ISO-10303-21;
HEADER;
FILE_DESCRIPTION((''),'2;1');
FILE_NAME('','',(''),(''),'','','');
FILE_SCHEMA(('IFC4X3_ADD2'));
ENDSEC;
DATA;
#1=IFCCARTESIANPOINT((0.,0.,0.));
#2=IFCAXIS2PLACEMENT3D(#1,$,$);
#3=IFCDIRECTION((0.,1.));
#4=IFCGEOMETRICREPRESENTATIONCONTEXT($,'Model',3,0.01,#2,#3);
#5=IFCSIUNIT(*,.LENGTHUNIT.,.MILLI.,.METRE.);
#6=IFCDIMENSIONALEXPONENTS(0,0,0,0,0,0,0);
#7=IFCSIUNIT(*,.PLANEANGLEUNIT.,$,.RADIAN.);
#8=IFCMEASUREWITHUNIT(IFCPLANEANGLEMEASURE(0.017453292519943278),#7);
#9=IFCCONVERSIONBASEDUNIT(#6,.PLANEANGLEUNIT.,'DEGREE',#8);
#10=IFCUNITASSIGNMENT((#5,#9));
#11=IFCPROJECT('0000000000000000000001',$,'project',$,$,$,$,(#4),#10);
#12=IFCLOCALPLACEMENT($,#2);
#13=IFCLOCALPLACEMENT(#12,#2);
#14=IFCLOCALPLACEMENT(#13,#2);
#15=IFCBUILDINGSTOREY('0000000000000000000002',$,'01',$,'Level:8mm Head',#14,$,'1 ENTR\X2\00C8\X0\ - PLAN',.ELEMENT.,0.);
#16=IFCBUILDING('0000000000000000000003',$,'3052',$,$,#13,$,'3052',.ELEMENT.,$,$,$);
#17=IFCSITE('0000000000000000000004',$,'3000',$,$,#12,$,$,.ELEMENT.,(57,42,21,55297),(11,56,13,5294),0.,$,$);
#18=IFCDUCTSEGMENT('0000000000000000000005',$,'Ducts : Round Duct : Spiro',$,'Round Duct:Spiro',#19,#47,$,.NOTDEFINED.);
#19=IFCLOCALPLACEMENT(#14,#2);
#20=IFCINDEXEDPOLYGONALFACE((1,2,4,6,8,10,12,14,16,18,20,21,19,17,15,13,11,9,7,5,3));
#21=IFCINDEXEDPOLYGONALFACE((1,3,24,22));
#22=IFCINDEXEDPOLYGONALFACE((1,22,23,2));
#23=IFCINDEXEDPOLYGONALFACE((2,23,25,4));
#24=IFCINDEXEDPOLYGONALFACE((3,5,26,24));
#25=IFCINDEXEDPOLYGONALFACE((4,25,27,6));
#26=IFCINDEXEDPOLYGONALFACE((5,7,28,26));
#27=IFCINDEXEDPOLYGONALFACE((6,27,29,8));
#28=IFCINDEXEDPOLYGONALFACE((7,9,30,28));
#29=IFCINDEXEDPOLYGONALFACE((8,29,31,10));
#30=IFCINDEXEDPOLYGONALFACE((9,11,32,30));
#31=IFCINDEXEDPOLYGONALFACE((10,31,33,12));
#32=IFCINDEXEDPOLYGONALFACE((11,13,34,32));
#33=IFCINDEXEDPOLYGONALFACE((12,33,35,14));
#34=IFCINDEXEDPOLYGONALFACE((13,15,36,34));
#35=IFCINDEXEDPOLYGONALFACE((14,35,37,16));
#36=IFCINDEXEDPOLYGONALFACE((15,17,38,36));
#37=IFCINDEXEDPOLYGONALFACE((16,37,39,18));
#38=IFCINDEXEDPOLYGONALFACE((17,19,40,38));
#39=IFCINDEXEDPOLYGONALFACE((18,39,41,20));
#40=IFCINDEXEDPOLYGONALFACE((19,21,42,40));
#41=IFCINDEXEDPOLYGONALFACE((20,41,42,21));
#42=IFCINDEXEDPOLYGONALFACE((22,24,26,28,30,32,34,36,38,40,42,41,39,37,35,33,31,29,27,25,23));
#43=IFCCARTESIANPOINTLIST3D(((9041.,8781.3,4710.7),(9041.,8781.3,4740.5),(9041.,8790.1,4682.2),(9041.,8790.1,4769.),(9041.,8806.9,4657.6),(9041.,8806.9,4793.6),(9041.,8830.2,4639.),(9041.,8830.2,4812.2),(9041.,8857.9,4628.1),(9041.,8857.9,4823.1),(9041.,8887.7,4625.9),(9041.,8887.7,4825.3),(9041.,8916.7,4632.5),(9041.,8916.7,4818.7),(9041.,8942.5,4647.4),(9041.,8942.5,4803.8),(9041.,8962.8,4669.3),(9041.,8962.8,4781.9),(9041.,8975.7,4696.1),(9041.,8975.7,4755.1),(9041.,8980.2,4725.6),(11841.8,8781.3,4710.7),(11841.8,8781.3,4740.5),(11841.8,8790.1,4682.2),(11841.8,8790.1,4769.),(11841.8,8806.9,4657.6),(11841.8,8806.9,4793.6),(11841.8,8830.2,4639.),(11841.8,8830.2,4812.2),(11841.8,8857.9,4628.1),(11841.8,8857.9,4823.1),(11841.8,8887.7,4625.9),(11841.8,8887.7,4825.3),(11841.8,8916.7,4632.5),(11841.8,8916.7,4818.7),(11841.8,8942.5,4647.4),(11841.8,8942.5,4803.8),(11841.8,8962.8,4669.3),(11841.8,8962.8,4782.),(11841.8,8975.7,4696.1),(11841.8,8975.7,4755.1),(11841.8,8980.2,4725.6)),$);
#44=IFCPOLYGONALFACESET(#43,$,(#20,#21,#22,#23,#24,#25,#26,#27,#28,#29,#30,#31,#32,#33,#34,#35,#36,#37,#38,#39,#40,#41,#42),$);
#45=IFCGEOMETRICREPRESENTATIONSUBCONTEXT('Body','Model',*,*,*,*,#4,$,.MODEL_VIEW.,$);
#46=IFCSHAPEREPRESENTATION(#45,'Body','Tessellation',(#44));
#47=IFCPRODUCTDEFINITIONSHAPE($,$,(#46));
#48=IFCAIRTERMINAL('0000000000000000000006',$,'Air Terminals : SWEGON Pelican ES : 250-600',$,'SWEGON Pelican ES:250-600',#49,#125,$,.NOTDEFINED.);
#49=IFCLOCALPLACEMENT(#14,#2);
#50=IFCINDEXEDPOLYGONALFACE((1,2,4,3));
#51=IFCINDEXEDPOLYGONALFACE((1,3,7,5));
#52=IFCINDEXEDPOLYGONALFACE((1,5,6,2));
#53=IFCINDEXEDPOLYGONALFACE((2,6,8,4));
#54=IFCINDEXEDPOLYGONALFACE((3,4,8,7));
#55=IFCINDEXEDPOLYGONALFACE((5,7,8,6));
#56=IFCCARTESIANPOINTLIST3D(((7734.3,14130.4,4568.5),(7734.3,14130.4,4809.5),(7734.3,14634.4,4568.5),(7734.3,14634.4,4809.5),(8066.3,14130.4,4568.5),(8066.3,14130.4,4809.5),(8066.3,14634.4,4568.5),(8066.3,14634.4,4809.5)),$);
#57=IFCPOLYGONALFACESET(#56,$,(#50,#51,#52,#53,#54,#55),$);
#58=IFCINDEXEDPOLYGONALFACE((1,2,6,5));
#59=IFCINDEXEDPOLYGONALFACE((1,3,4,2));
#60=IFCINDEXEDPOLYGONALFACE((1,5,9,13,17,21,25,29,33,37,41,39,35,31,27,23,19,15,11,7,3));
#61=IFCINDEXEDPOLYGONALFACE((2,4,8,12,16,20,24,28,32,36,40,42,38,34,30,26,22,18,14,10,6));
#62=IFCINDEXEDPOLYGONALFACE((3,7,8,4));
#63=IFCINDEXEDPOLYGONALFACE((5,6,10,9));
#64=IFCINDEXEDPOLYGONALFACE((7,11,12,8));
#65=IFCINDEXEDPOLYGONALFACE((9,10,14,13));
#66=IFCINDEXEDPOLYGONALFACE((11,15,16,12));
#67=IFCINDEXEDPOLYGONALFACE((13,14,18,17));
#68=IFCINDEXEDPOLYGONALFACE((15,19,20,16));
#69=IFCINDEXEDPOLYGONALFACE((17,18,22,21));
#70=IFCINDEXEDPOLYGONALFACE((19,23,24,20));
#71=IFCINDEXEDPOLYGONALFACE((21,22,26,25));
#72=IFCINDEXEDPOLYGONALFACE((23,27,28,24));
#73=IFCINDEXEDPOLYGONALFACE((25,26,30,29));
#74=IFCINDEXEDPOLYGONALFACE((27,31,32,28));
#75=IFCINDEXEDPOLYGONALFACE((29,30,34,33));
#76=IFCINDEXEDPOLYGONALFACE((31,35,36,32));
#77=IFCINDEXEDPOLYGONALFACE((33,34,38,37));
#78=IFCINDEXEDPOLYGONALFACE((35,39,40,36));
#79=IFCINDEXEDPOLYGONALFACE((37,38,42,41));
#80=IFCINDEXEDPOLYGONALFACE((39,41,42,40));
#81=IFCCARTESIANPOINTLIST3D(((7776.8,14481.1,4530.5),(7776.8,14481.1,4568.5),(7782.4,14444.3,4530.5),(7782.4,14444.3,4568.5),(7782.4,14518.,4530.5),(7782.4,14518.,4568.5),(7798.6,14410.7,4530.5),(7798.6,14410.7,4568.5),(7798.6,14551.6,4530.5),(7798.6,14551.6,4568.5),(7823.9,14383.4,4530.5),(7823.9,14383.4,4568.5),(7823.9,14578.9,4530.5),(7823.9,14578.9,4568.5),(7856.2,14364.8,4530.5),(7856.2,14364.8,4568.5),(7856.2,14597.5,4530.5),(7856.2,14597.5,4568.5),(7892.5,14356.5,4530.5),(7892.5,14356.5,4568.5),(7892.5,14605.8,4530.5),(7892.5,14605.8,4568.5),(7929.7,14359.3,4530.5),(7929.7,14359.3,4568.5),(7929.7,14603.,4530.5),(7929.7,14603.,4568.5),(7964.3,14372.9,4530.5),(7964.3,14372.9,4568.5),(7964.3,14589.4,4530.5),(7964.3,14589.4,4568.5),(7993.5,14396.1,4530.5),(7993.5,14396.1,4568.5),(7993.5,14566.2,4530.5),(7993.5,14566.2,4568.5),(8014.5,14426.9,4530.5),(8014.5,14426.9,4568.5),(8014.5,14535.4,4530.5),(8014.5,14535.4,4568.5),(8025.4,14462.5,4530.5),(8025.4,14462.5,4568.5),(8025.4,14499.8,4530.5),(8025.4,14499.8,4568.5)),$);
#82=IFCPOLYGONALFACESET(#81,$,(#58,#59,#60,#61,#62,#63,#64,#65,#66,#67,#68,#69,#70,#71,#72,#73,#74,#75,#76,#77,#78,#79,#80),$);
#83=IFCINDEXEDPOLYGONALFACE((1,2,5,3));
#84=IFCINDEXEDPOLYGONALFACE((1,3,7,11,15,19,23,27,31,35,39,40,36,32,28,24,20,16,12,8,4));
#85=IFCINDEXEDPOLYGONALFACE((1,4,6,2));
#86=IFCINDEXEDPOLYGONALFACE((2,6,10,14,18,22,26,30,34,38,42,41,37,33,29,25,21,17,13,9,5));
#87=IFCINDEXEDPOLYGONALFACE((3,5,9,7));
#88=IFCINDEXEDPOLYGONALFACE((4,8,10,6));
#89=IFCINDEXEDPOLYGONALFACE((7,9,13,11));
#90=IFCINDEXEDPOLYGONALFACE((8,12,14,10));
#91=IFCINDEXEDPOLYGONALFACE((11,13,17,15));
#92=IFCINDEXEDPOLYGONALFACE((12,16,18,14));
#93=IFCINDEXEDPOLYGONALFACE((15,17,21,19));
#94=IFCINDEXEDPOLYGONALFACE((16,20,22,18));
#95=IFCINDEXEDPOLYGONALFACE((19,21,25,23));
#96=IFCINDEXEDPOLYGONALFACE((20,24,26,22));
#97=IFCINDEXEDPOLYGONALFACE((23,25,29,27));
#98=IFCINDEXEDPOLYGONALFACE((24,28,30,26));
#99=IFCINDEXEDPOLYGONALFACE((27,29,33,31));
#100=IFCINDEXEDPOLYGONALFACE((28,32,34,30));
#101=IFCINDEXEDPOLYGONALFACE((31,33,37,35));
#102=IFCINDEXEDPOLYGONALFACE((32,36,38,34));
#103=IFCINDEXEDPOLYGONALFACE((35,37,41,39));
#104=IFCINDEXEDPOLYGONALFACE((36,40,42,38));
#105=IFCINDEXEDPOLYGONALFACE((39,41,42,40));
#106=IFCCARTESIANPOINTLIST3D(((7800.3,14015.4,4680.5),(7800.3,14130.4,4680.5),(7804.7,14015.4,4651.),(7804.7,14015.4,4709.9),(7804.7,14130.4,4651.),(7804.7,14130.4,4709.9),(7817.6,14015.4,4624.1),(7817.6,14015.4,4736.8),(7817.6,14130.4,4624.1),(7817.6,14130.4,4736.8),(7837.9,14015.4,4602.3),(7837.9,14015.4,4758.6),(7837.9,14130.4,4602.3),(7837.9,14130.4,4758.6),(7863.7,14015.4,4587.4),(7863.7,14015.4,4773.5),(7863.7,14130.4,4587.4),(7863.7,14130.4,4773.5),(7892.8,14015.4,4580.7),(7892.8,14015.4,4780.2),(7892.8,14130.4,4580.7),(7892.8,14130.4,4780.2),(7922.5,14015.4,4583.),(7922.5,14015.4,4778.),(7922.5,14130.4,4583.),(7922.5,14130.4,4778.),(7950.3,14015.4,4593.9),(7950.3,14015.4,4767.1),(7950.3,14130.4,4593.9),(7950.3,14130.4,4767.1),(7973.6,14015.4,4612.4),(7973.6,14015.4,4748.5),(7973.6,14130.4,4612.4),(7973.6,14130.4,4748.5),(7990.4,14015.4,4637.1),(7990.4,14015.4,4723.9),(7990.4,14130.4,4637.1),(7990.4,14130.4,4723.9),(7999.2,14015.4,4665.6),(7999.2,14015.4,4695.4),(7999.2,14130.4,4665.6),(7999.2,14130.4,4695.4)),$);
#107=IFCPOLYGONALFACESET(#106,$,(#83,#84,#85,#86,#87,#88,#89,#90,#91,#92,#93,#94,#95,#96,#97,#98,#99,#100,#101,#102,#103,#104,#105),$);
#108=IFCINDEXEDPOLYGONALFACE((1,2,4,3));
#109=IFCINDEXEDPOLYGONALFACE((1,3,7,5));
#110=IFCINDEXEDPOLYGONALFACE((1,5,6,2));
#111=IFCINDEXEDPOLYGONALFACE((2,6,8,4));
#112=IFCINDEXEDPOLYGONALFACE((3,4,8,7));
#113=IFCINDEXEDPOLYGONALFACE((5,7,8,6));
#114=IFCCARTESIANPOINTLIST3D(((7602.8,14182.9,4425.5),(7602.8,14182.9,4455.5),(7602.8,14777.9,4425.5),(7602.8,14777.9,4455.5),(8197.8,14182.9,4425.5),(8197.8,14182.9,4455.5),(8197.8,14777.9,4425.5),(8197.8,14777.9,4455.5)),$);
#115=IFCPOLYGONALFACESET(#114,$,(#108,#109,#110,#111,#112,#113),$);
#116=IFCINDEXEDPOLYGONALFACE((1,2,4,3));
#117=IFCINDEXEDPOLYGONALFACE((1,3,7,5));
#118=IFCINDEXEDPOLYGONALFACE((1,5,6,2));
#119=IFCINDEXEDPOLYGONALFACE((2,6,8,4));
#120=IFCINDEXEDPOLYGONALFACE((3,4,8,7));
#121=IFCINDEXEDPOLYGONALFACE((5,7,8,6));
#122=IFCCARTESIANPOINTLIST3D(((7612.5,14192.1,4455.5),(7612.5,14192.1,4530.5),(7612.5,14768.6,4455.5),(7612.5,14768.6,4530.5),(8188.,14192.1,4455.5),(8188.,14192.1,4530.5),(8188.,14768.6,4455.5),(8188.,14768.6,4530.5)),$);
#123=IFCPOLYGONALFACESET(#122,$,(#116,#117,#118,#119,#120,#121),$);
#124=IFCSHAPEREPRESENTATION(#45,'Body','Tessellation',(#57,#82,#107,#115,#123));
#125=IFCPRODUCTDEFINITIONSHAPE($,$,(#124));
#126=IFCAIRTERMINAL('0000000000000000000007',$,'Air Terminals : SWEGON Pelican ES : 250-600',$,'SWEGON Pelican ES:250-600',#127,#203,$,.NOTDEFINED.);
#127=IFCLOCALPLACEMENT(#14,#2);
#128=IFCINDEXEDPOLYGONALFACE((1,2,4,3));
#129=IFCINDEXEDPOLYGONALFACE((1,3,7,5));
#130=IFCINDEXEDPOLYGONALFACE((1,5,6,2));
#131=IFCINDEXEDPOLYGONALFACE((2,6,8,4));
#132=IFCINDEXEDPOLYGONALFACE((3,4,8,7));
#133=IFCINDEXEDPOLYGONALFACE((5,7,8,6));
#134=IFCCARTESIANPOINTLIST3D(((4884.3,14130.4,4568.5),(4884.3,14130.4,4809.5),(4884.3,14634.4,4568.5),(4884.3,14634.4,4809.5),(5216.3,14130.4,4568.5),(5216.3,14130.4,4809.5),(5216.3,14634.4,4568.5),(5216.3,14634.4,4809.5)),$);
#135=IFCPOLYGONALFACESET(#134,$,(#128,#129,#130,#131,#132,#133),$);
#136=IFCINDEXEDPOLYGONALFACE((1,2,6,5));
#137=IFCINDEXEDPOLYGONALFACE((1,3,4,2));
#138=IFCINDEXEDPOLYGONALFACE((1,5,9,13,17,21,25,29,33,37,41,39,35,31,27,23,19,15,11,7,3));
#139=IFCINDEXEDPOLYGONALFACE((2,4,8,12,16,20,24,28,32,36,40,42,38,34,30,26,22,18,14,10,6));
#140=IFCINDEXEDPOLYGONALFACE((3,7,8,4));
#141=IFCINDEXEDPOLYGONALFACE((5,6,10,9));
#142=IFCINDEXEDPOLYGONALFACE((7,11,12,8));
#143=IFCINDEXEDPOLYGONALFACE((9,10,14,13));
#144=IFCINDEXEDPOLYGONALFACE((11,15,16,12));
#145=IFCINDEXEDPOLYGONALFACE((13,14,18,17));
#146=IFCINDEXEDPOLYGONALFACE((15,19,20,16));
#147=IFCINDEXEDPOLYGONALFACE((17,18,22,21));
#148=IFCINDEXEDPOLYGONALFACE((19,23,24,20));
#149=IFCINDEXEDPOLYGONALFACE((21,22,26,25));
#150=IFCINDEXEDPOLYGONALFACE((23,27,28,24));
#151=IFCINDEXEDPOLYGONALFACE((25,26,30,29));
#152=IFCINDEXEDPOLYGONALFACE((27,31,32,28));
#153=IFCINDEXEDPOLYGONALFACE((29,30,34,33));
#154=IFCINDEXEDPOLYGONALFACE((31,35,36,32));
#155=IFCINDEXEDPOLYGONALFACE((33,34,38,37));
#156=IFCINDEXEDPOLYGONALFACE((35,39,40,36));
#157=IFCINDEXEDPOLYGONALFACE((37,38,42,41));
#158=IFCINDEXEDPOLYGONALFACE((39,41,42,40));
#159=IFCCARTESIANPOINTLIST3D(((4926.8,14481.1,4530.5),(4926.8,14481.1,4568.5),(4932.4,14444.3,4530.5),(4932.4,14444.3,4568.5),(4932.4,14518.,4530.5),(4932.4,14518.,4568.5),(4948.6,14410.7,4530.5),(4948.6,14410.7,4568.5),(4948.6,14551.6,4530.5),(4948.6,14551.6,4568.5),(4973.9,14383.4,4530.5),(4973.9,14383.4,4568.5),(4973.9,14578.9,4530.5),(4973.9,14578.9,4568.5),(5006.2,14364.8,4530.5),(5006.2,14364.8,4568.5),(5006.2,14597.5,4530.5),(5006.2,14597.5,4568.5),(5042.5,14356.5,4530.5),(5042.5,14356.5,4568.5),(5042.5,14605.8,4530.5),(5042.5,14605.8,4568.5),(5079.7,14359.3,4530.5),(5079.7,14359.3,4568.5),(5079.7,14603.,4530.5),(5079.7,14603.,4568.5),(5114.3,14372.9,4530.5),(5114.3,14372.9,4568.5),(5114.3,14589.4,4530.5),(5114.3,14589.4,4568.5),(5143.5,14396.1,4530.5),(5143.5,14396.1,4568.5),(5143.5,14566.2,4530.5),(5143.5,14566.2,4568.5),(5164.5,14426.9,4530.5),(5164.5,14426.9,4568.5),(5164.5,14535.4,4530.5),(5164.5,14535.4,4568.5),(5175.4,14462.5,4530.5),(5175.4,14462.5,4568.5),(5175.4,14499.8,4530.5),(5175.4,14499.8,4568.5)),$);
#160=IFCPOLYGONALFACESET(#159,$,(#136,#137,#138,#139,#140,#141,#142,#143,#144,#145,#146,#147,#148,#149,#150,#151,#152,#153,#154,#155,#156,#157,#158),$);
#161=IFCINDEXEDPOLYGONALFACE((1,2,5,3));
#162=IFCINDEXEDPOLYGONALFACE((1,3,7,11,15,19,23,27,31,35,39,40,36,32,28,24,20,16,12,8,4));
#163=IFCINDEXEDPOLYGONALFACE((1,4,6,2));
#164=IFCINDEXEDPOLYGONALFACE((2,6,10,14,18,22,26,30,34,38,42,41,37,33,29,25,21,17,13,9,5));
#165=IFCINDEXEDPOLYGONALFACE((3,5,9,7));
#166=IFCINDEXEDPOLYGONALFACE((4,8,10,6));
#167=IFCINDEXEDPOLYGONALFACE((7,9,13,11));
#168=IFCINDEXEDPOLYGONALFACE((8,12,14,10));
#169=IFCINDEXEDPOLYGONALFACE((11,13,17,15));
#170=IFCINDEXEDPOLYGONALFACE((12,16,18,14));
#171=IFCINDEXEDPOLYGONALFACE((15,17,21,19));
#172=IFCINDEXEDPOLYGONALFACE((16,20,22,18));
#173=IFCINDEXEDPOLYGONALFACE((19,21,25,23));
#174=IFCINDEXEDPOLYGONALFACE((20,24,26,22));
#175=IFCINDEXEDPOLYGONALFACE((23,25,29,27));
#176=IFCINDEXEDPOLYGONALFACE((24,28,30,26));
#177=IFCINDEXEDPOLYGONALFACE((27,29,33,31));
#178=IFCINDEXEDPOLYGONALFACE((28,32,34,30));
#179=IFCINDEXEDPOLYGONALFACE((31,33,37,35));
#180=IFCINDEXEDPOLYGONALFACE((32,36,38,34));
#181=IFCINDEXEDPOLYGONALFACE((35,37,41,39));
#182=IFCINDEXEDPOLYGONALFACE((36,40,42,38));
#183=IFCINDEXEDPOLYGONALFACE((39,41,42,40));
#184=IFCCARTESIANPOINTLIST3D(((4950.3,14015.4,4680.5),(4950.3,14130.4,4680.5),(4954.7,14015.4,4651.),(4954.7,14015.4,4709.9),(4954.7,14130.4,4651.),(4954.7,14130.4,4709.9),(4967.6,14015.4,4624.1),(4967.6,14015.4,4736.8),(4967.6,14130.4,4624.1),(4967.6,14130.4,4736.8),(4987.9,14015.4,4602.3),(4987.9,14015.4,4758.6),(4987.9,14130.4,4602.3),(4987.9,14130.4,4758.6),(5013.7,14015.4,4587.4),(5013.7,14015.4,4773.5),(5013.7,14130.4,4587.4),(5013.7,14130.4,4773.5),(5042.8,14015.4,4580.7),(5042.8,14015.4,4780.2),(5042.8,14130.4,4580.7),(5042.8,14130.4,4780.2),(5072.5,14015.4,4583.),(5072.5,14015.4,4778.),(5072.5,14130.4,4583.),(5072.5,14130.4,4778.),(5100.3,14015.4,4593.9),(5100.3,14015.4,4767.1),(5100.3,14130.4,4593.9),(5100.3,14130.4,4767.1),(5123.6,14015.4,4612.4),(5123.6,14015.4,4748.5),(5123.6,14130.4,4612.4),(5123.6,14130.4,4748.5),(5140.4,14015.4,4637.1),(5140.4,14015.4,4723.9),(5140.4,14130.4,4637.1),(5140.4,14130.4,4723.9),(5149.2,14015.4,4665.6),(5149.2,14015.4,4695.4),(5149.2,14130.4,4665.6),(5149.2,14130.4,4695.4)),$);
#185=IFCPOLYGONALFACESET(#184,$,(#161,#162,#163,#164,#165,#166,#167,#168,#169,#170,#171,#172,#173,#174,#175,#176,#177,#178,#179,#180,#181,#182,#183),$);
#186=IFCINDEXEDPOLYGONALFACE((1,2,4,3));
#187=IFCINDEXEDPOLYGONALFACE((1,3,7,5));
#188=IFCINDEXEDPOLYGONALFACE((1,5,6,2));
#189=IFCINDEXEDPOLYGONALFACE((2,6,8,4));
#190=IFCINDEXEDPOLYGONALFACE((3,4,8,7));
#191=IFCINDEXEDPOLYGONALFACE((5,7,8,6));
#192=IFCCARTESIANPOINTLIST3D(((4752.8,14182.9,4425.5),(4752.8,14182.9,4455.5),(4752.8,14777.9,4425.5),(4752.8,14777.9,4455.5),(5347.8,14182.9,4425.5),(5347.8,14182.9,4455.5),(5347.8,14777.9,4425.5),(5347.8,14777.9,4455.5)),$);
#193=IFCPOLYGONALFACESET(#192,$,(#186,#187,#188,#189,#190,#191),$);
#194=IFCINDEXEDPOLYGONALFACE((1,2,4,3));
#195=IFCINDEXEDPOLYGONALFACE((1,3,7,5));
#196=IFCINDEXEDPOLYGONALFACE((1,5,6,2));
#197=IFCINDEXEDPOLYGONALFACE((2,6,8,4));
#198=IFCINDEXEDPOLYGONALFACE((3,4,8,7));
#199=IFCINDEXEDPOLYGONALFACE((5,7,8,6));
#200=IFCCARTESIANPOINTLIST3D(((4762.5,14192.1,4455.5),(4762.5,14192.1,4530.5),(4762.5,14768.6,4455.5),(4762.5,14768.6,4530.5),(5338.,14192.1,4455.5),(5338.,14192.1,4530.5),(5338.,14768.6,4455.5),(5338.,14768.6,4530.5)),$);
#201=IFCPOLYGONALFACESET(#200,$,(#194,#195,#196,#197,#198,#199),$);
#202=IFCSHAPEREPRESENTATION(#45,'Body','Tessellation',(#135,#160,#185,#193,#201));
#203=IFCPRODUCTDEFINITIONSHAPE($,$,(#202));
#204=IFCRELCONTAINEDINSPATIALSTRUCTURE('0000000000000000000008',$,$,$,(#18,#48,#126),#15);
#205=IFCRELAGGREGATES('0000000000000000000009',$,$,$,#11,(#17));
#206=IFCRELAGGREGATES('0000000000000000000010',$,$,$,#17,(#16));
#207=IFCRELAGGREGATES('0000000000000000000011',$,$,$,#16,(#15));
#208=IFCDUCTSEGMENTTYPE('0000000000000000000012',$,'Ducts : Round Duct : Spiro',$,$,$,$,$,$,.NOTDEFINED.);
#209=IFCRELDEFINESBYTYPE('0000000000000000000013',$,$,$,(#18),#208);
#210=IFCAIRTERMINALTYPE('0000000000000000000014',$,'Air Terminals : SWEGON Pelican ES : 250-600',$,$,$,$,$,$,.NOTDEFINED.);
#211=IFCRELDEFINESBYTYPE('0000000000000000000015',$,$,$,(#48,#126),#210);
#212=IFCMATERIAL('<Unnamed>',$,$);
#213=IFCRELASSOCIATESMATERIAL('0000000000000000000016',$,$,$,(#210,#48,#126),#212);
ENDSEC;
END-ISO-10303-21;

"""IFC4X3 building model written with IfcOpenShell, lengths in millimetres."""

from ifc_helpers import new_model, entity, si_unit, converted_unit, direction, frame, frame_2d, origin, origin_2d_with_axis, place, context, subcontext, project, spatial, rectangle, circle, extrude, source, transform, mapped, material, type_object, type_shapes, element, save


model = new_model("IFC4X3")

# Units and contexts
model_context = context("Model", 3, precision=0.01, world=origin(), true_north=direction((0.0, 1.0)))
body_context = subcontext(model_context, "Body", "Model", "MODEL_VIEW")
ifc_project = project(units=[si_unit("LENGTHUNIT", "METRE", prefix="MILLI"), converted_unit("PLANEANGLEUNIT", "DEGREE", entity("IfcPlaneAngleMeasure", 0.017453292519943278), si_unit("PLANEANGLEUNIT", "RADIAN"), dimensions=[0, 0, 0, 0, 0, 0, 0])], contexts=[model_context])

# Site, building, storey
site_placement = place(None, origin())
site = spatial("IfcSite", under=ifc_project, at=site_placement, Name="3000", CompositionType="ELEMENT", RefLatitude=(57, 42, 21, 55297), RefLongitude=(11, 56, 13, 5294), RefElevation=0.0)
building_placement = place(site_placement, origin())
building = spatial("IfcBuilding", under=site, at=building_placement, Name="3052", LongName="3052", CompositionType="ELEMENT")
storey_placement = place(building_placement, origin())
storey = spatial("IfcBuildingStorey", under=building, at=storey_placement, Name="01", ObjectType="Level:8mm Head", LongName="1 ENTRÈ - PLAN", CompositionType="ELEMENT", Elevation=0.0)

# Duct segment
duct_segment_type = type_object("IfcDuctSegmentType", Name="Ducts : Round Duct : Spiro", PredefinedType="NOTDEFINED")
duct_segment_1_placement = place(storey_placement, frame((9041.0, 8778.6, 4624.0)))
element("IfcDuctSegment", 1, at=duct_segment_1_placement, inside=storey, type_object=duct_segment_type, Name="Ducts : Round Duct : Spiro", ObjectType="Round Duct:Spiro", PredefinedType="NOTDEFINED", context=body_context, shape_type="SweptSolid", body=[
    extrude(circle(Radius=100.0, at=frame_2d((0.0, 0.0), x_axis=(1.0, 0.0))), frame((0.0, 101.6, 101.6), z_axis=(1.0, 0.0, 0.000006), x_axis=(0.0, 1.0, 0.0)), (0.0, 0.0, 1.0), 2800.8),
])

# Air terminals
ifc_material_1 = material(Name="<Unnamed>")
air_terminal_type_1 = type_object("IfcAirTerminalType", Name="Air Terminals : SWEGON Pelican ES : 250-600", PredefinedType="NOTDEFINED", material=ifc_material_1)
shared_shape_1 = source(origin(), body_context, "Body", "SweptSolid", [
    extrude(rectangle(XDim=504.0, YDim=332.0, at=origin_2d_with_axis()), frame((0.0, -98.0, -354.0), z_axis=(0.0, 0.0, 1.0), x_axis=(0.0, 1.0, 0.0)), (0.0, 0.0, 1.0), 241.0),
    extrude(circle(Radius=125.0, at=frame_2d((0.0, 0.0), x_axis=(1.0, 0.0))), frame((-1.6, 0.8, -113.0)), (0.0, 0.0, 1.0), 38.0),
    extrude(circle(Radius=100.0, at=frame_2d((0.0, 0.0), x_axis=(1.0, 0.0))), frame((0.0, -465.0, -225.0), z_axis=(0.0, 1.0, 0.0), x_axis=(1.0, 0.0, 0.0)), (0.0, 0.0, 1.0), 115.0),
    extrude(rectangle(XDim=595.0, YDim=595.0, at=frame_2d((0.0, 0.0), x_axis=(1.0, 0.0))), frame((0.0, 0.0, 0.0), z_axis=(0.0, 0.0, 1.0), x_axis=(0.0, 1.0, 0.0)), (0.0, 0.0, 1.0), 30.0),
    extrude(rectangle(XDim=576.5, YDim=575.5, at=origin_2d_with_axis()), frame((0.0, 0.0, -75.0), z_axis=(0.0, 0.0, 1.0), x_axis=(0.0, 1.0, 0.0)), (0.0, 0.0, 1.0), 75.0),
])
type_shapes(air_terminal_type_1, [shared_shape_1])
for number, where, z_axis, x_axis, name in (
    (2, (7900.3, 14480.4, 4455.5), (0.0, 0.0, -1.0), (-1.0, 0.0, 0.0), "Air Terminals : SWEGON Pelican ES : 250-600"),
    (3, (5050.3, 14480.4, 4455.5), (0.0, 0.0, -1.0), (-1.0, 0.0, 0.0), "Air Terminals : SWEGON Pelican ES : 250-600"),
):
    element("IfcAirTerminal", number, at=place(storey_placement, frame(where, z_axis=z_axis, x_axis=x_axis)), inside=storey, type_object=air_terminal_type_1, material=ifc_material_1, Name=name, ObjectType="SWEGON Pelican ES:250-600", PredefinedType="NOTDEFINED", context=body_context, shape_type="MappedRepresentation", body=[
        mapped(shared_shape_1, transform((0.0, 0.0, 0.0), scale=1.0)),
    ])

save(model, "model.ifc")
